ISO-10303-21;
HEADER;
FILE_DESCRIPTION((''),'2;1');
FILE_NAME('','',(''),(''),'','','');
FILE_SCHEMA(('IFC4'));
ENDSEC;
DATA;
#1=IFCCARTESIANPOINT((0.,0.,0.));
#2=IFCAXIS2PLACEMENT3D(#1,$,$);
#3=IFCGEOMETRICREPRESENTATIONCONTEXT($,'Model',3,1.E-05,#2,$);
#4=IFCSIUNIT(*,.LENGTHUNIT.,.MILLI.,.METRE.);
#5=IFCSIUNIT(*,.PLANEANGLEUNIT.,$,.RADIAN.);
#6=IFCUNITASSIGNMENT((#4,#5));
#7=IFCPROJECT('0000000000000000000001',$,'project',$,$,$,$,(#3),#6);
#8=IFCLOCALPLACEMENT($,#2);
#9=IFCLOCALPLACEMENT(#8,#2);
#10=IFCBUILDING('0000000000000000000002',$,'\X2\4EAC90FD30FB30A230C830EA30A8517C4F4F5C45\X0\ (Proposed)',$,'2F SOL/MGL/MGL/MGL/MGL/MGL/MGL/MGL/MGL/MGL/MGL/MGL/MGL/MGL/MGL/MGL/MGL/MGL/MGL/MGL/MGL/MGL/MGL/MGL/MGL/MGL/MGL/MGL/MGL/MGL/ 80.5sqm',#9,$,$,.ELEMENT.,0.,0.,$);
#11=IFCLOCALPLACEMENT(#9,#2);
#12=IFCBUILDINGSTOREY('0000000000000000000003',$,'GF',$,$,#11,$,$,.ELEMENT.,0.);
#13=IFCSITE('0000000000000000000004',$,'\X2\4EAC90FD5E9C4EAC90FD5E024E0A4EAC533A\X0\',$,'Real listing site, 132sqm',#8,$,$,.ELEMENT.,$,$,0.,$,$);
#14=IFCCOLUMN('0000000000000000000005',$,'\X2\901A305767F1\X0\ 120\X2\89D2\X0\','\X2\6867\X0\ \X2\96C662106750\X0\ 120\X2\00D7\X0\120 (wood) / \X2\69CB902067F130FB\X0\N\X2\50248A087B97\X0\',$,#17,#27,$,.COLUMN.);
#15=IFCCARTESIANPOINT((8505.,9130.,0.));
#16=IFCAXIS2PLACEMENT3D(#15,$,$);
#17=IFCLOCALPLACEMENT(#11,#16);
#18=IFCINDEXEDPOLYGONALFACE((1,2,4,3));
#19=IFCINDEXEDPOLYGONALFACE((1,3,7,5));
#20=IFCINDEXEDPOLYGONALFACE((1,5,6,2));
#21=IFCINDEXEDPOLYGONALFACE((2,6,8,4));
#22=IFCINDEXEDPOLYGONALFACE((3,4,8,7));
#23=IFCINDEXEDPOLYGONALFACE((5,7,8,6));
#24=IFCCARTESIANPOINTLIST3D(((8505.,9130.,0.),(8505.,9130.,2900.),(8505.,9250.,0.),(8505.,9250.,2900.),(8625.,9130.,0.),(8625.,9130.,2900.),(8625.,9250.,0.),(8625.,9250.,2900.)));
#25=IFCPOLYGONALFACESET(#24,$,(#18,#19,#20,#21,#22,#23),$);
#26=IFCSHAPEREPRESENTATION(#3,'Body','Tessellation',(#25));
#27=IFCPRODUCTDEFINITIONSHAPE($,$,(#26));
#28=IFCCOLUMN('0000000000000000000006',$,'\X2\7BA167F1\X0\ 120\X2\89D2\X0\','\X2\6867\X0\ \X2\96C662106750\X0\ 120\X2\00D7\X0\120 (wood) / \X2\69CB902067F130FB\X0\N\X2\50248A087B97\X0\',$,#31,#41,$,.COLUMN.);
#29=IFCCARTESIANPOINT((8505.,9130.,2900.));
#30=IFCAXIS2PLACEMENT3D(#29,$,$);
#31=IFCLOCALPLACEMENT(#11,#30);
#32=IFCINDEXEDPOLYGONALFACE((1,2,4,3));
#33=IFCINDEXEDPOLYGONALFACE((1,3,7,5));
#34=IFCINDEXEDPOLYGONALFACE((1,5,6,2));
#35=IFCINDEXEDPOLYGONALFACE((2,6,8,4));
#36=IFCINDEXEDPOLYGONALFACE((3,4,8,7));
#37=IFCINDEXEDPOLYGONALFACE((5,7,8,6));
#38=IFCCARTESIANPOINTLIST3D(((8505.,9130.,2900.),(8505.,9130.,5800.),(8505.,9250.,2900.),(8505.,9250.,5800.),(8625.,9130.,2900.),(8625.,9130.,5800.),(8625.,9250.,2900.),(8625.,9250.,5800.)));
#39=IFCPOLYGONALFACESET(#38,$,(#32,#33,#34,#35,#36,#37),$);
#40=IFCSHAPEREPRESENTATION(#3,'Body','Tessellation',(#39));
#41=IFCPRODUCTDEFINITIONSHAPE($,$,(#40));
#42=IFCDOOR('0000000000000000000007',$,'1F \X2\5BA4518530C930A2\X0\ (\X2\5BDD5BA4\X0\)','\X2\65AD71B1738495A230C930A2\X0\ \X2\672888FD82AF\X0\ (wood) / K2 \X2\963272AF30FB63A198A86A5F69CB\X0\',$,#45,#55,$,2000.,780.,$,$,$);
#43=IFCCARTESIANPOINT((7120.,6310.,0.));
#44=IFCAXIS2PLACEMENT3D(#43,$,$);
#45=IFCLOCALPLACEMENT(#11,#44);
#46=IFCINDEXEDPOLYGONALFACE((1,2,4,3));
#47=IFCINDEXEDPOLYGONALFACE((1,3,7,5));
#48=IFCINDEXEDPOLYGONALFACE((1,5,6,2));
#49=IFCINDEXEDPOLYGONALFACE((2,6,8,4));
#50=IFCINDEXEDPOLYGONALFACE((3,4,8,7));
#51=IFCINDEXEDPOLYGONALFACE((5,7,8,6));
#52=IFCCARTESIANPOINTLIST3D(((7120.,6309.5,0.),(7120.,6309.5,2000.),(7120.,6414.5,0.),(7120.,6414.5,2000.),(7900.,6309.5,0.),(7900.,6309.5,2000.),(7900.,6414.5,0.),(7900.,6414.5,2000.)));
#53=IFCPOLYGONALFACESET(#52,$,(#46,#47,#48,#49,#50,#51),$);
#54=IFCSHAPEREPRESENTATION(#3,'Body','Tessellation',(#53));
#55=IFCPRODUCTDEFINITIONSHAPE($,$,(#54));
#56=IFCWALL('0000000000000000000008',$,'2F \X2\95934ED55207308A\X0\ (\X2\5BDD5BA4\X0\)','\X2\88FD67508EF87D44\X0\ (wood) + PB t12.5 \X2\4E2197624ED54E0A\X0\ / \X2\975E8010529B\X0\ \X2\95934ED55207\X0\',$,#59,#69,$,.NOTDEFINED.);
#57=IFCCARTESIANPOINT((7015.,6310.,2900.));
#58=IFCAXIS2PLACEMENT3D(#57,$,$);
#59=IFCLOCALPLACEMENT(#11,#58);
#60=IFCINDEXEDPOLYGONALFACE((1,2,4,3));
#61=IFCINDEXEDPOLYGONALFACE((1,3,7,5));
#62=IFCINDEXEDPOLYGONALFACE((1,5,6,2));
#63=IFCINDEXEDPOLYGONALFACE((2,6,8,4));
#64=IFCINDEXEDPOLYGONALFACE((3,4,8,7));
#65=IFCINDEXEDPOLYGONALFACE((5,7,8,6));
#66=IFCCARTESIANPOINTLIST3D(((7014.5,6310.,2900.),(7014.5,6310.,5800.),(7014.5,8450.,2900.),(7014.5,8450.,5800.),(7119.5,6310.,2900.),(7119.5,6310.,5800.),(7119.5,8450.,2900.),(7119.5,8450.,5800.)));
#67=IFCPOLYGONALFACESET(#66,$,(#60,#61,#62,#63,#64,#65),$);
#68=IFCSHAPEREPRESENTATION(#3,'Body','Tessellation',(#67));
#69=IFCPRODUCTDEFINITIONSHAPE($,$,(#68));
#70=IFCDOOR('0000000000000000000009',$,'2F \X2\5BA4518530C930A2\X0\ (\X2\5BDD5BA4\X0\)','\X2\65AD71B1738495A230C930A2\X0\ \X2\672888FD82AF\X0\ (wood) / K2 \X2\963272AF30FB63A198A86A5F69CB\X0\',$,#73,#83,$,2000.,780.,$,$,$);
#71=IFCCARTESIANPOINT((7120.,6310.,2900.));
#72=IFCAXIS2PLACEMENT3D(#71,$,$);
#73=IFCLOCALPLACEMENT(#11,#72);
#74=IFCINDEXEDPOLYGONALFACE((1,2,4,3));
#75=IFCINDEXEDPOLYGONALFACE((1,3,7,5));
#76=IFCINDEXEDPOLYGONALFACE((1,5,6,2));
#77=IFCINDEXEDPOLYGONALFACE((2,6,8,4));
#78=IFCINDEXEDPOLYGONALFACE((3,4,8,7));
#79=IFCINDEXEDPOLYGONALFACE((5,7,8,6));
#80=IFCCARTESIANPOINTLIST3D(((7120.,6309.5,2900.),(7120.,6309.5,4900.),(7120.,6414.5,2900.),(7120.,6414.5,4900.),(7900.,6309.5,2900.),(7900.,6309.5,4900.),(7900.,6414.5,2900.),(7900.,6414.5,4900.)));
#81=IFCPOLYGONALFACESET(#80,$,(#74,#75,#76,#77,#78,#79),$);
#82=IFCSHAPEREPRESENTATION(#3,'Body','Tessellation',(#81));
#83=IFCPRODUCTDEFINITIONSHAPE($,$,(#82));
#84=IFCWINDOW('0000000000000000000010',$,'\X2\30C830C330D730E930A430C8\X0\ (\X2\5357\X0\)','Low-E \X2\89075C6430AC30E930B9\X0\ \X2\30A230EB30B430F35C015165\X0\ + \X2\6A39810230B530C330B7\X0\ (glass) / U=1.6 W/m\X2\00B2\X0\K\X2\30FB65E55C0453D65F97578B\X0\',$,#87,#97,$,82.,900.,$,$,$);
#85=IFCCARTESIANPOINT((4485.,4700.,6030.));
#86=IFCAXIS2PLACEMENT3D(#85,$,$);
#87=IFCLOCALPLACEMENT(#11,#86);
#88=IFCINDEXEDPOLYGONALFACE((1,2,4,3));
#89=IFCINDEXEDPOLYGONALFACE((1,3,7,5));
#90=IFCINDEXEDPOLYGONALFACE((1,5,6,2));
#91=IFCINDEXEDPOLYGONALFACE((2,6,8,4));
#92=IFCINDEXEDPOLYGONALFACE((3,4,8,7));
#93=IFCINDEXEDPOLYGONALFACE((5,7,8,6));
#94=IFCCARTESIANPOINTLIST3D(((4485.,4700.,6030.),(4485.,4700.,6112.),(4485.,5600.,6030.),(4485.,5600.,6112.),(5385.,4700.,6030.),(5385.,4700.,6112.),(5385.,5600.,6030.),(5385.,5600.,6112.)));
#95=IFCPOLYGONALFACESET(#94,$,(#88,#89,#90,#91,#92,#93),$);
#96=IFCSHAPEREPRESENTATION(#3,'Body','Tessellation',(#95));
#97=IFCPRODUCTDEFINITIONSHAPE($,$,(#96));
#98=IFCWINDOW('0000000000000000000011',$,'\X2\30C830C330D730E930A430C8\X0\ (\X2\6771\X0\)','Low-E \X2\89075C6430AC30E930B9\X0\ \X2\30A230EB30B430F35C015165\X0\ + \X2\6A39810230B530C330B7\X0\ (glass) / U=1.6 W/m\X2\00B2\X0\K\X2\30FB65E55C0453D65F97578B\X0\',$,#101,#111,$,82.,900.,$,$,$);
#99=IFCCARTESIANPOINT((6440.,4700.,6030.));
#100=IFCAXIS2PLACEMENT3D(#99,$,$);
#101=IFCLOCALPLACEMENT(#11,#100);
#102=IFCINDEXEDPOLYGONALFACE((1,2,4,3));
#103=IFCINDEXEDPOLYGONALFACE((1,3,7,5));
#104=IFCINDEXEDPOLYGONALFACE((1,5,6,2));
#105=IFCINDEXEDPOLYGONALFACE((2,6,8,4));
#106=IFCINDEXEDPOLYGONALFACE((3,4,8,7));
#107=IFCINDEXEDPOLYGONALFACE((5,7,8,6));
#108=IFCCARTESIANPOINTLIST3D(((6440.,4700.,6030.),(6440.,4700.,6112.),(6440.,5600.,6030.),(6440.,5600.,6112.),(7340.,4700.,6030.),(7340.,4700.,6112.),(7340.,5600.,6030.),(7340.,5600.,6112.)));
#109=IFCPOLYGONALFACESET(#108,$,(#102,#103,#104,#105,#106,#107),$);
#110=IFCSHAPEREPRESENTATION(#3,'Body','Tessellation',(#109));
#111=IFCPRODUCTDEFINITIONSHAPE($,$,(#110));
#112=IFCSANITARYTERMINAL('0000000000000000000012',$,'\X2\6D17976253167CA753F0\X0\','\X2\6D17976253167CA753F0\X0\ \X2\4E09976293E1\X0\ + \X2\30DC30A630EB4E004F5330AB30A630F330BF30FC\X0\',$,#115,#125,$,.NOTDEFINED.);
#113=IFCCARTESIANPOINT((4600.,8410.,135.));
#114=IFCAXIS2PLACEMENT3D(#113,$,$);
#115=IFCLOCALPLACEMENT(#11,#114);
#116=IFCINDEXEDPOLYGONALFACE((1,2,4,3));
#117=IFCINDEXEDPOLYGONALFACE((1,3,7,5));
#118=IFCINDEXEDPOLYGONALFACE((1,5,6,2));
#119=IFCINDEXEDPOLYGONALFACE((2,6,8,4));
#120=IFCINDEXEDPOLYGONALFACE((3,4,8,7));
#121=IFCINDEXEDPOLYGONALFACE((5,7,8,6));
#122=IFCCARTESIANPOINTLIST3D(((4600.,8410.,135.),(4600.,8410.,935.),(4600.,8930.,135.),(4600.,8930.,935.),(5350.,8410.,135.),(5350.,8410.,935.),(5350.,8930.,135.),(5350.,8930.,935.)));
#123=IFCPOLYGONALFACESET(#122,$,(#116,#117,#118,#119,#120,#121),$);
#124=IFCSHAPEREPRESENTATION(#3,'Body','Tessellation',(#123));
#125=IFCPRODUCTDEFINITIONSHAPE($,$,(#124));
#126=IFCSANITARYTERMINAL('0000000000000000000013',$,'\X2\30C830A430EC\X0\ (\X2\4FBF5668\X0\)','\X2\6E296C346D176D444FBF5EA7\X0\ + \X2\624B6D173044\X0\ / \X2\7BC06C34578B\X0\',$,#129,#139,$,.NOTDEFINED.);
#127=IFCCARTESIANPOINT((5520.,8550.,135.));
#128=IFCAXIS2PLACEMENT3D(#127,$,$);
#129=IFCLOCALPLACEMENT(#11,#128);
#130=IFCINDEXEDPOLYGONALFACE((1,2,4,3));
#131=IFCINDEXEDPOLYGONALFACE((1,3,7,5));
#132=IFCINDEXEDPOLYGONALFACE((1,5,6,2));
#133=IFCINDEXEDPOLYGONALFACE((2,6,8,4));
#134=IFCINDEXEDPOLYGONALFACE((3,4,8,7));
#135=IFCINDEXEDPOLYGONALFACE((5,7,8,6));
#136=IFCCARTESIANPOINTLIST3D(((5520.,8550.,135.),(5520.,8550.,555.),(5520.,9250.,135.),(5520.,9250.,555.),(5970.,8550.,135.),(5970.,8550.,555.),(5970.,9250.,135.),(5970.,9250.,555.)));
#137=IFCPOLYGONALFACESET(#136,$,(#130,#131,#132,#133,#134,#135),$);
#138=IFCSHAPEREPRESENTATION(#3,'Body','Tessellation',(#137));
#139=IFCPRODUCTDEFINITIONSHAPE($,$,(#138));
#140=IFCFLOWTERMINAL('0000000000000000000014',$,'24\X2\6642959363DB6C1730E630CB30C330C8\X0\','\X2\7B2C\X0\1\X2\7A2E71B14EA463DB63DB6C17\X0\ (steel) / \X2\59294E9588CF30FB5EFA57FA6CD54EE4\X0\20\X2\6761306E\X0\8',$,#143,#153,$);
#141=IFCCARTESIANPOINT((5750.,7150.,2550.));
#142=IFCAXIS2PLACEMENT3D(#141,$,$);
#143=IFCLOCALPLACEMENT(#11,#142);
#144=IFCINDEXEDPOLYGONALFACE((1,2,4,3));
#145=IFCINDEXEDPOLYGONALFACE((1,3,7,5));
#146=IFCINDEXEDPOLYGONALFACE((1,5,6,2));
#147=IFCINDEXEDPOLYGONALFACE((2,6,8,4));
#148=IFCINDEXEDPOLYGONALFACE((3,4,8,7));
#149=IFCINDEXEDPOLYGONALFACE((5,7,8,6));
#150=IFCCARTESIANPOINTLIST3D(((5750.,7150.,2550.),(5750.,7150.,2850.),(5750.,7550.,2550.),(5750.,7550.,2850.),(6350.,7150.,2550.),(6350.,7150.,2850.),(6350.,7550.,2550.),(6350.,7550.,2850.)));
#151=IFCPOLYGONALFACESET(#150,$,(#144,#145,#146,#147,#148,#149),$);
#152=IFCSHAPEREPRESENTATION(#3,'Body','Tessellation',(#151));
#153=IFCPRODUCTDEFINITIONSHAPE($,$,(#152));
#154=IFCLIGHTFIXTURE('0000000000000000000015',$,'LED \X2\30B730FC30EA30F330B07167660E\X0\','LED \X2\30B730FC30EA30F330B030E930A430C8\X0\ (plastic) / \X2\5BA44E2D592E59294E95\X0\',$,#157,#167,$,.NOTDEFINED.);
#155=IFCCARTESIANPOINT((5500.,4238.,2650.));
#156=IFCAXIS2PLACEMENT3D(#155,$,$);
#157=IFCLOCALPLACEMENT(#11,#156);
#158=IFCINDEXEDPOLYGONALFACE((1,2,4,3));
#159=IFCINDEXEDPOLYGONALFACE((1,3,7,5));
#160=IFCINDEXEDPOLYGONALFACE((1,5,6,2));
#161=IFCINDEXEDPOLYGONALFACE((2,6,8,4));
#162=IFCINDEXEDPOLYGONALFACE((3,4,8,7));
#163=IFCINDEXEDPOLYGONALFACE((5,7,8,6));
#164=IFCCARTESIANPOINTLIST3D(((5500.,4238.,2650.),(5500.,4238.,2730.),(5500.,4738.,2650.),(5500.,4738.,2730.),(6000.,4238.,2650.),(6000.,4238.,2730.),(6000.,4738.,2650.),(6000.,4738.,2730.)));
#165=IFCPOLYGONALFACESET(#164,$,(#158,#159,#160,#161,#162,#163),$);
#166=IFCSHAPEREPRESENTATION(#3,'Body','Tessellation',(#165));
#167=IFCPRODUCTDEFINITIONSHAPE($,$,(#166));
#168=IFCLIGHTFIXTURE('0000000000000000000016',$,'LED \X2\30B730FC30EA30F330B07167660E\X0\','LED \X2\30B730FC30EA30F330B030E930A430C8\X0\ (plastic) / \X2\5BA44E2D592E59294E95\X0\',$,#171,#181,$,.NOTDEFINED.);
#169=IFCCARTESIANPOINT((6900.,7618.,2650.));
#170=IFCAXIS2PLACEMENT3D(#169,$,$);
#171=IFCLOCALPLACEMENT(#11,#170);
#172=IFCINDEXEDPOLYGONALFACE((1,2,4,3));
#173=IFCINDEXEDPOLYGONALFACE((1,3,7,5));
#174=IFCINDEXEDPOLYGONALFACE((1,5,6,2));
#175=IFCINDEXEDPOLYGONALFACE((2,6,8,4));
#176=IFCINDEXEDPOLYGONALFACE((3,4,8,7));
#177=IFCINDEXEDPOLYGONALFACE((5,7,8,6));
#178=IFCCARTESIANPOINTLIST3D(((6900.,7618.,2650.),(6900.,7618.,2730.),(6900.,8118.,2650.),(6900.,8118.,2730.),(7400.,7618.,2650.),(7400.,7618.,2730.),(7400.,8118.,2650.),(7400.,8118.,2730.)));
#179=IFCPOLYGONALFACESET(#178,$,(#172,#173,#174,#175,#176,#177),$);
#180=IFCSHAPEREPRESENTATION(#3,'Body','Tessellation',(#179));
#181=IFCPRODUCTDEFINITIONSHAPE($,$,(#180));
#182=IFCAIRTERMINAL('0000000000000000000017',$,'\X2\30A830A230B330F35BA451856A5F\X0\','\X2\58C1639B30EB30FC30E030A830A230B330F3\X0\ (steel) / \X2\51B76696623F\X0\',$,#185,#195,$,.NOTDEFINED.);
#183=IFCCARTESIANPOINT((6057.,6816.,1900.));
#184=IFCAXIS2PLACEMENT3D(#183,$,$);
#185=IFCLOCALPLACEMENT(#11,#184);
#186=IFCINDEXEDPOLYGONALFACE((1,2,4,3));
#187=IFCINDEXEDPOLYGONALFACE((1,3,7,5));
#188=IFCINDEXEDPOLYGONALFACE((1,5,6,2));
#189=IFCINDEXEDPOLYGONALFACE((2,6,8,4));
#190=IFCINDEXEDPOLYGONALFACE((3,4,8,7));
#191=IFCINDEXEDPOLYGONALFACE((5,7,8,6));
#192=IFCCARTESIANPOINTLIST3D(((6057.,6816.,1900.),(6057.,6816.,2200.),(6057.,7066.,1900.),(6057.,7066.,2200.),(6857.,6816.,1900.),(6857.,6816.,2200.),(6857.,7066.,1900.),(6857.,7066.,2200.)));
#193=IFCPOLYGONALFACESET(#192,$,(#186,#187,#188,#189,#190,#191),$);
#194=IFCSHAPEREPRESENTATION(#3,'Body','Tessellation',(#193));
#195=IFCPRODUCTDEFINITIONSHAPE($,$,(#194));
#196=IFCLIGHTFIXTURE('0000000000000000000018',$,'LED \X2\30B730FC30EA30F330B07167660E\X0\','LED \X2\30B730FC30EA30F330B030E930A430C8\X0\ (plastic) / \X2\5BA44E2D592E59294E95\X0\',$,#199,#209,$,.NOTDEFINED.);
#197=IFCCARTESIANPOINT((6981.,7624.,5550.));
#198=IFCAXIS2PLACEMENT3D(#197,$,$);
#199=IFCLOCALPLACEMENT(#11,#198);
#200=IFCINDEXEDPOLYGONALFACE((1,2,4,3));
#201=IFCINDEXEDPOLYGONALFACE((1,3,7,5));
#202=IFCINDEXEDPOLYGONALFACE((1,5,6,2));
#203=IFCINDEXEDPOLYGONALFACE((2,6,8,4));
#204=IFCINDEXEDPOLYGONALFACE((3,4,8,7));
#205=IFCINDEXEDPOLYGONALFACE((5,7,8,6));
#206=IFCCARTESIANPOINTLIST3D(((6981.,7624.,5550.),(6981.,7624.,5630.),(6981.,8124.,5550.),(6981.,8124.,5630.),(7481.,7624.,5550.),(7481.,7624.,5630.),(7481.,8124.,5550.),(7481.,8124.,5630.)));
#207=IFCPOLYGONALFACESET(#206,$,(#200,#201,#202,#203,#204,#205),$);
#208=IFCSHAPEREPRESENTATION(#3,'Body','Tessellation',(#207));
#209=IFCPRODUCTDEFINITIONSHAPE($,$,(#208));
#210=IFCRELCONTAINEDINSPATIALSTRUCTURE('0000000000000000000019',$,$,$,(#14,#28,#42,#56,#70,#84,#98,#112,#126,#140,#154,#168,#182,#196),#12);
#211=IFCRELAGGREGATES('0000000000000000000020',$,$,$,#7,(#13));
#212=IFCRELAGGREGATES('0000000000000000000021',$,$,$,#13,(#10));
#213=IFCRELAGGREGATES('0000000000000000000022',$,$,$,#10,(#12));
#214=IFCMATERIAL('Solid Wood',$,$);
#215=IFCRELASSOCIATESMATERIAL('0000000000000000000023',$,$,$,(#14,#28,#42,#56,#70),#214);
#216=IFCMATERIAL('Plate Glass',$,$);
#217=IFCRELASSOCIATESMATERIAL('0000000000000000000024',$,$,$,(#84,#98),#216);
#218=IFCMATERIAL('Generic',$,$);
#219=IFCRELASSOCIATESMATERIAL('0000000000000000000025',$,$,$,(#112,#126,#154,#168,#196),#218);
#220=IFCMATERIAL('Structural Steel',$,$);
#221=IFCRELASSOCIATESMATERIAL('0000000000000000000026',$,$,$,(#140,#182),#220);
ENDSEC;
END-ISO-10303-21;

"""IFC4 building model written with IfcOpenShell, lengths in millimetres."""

from ifc_helpers import new_model, si_unit, frame, frame_2d, origin, place, context, project, spatial, rectangle, extrude, material, element, save


model = new_model("IFC4")

# Units and contexts
model_context = context("Model", 3, precision=1e-05, world=origin())
ifc_project = project(units=[si_unit("LENGTHUNIT", "METRE", prefix="MILLI"), si_unit("PLANEANGLEUNIT", "RADIAN")], contexts=[model_context])

# Site, building, storey
site_placement = place(None, origin())
site = spatial("IfcSite", under=ifc_project, at=site_placement, Name="京都府京都市上京区", ObjectType="Real listing site, 132sqm", CompositionType="ELEMENT", RefElevation=0.0)
building_placement = place(site_placement, origin())
building = spatial("IfcBuilding", under=site, at=building_placement, Name="京都・アトリエ兼住居 (Proposed)", ObjectType="2F SOL/MGL/MGL/MGL/MGL/MGL/MGL/MGL/MGL/MGL/MGL/MGL/MGL/MGL/MGL/MGL/MGL/MGL/MGL/MGL/MGL/MGL/MGL/MGL/MGL/MGL/MGL/MGL/MGL/MGL/ 80.5sqm", CompositionType="ELEMENT", ElevationOfRefHeight=0.0, ElevationOfTerrain=0.0)
storey_placement = place(building_placement, origin())
storey = spatial("IfcBuildingStorey", under=building, at=storey_placement, Name="GF", CompositionType="ELEMENT", Elevation=0.0)

# Columns
ifc_material_1 = material(Name="Solid Wood")
column_1_placement = place(storey_placement, frame((8505.0, 9130.0, 0.0)))
element("IfcColumn", 1, at=column_1_placement, inside=storey, material=ifc_material_1, Name="通し柱 120角", Description="桧 集成材 120×120 (wood) / 構造柱・N値計算", PredefinedType="COLUMN", context=model_context, shape_type="SweptSolid", body=[
    extrude(rectangle(XDim=120.0, YDim=120.0, at=frame_2d((60.0, 60.0))), frame((8505.0, 9130.0, 0.0)), (0.0, 0.0, 1.0), 2900.0),
])
column_2_placement = place(storey_placement, frame((8505.0, 9130.0, 2900.0)))
element("IfcColumn", 2, at=column_2_placement, inside=storey, material=ifc_material_1, Name="管柱 120角", Description="桧 集成材 120×120 (wood) / 構造柱・N値計算", PredefinedType="COLUMN", context=model_context, shape_type="SweptSolid", body=[
    extrude(rectangle(XDim=120.0, YDim=120.0, at=frame_2d((60.0, 60.0))), frame((8505.0, 9130.0, 2900.0)), (0.0, 0.0, 1.0), 2900.0),
])

# Door
door_1_placement = place(storey_placement, frame((7120.0, 6310.0, 0.0)))
element("IfcDoor", 3, at=door_1_placement, inside=storey, material=ifc_material_1, Name="1F 室内ドア (寝室)", Description="断熱玄関ドア 木製芯 (wood) / K2 防犯・採風機構", OverallHeight=2000.0, OverallWidth=780.0, context=model_context, shape_type="SweptSolid", body=[
    extrude(rectangle(XDim=780.0, YDim=105.0, at=frame_2d((390.0, 52.0))), frame((7120.0, 6310.0, 0.0)), (0.0, 0.0, 1.0), 2000.0),
])

# Wall
wall_1_placement = place(storey_placement, frame((7015.0, 6310.0, 2900.0)))
element("IfcWall", 4, at=wall_1_placement, inside=storey, material=ifc_material_1, Name="2F 間仕切り (寝室)", Description="製材軸組 (wood) + PB t12.5 両面仕上 / 非耐力 間仕切", PredefinedType="NOTDEFINED", context=model_context, shape_type="SweptSolid", body=[
    extrude(rectangle(XDim=105.0, YDim=2140.0, at=frame_2d((52.0, 1070.0))), frame((7015.0, 6310.0, 2900.0)), (0.0, 0.0, 1.0), 2900.0),
])

# Door
door_2_placement = place(storey_placement, frame((7120.0, 6310.0, 2900.0)))
element("IfcDoor", 5, at=door_2_placement, inside=storey, material=ifc_material_1, Name="2F 室内ドア (寝室)", Description="断熱玄関ドア 木製芯 (wood) / K2 防犯・採風機構", OverallHeight=2000.0, OverallWidth=780.0, context=model_context, shape_type="SweptSolid", body=[
    extrude(rectangle(XDim=780.0, YDim=105.0, at=frame_2d((390.0, 52.0))), frame((7120.0, 6310.0, 2900.0)), (0.0, 0.0, 1.0), 2000.0),
])

# Windows
ifc_material_2 = material(Name="Plate Glass")
window_1_placement = place(storey_placement, frame((4485.0, 4700.0, 6030.0)))
element("IfcWindow", 6, at=window_1_placement, inside=storey, material=ifc_material_2, Name="トップライト (南)", Description="Low-E 複層ガラス アルゴン封入 + 樹脂サッシ (glass) / U=1.6 W/m²K・日射取得型", OverallHeight=82.0, OverallWidth=900.0, context=model_context, shape_type="SweptSolid", body=[
    extrude(rectangle(XDim=900.0, YDim=900.0, at=frame_2d((450.0, 450.0))), frame((4485.0, 4700.0, 6030.0)), (0.0, 0.0, 1.0), 82.0),
])
window_2_placement = place(storey_placement, frame((6440.0, 4700.0, 6030.0)))
element("IfcWindow", 7, at=window_2_placement, inside=storey, material=ifc_material_2, Name="トップライト (東)", Description="Low-E 複層ガラス アルゴン封入 + 樹脂サッシ (glass) / U=1.6 W/m²K・日射取得型", OverallHeight=82.0, OverallWidth=900.0, context=model_context, shape_type="SweptSolid", body=[
    extrude(rectangle(XDim=900.0, YDim=900.0, at=frame_2d((450.0, 450.0))), frame((6440.0, 4700.0, 6030.0)), (0.0, 0.0, 1.0), 82.0),
])

# Sanitary terminals
ifc_material_3 = material(Name="Generic")
sanitary_terminal_1_placement = place(storey_placement, frame((4600.0, 8410.0, 135.0)))
element("IfcSanitaryTerminal", 8, at=sanitary_terminal_1_placement, inside=storey, material=ifc_material_3, Name="洗面化粧台", Description="洗面化粧台 三面鏡 + ボウル一体カウンター", PredefinedType="NOTDEFINED", context=model_context, shape_type="SweptSolid", body=[
    extrude(rectangle(XDim=750.0, YDim=520.0, at=frame_2d((375.0, 260.0))), frame((4600.0, 8410.0, 135.0)), (0.0, 0.0, 1.0), 800.0),
])
sanitary_terminal_2_placement = place(storey_placement, frame((5520.0, 8550.0, 135.0)))
element("IfcSanitaryTerminal", 9, at=sanitary_terminal_2_placement, inside=storey, material=ifc_material_3, Name="トイレ (便器)", Description="温水洗浄便座 + 手洗い / 節水型", PredefinedType="NOTDEFINED", context=model_context, shape_type="SweptSolid", body=[
    extrude(rectangle(XDim=450.0, YDim=700.0, at=frame_2d((225.0, 350.0))), frame((5520.0, 8550.0, 135.0)), (0.0, 0.0, 1.0), 420.0),
])

# Flow terminal
ifc_material_4 = material(Name="Structural Steel")
flow_terminal_placement = place(storey_placement, frame((5750.0, 7150.0, 2550.0)))
element("IfcFlowTerminal", 10, at=flow_terminal_placement, inside=storey, material=ifc_material_4, Name="24時間換気ユニット", Description="第1種熱交換換気 (steel) / 天井裏・建基法令20条の8", context=model_context, shape_type="SweptSolid", body=[
    extrude(rectangle(XDim=600.0, YDim=400.0, at=frame_2d((300.0, 200.0))), frame((5750.0, 7150.0, 2550.0)), (0.0, 0.0, 1.0), 300.0),
])

# Light fixtures
light_fixture_1_placement = place(storey_placement, frame((5500.0, 4238.0, 2650.0)))
element("IfcLightFixture", 11, at=light_fixture_1_placement, inside=storey, material=ifc_material_3, Name="LED シーリング照明", Description="LED シーリングライト (plastic) / 室中央天井", PredefinedType="NOTDEFINED", context=model_context, shape_type="SweptSolid", body=[
    extrude(rectangle(XDim=500.0, YDim=500.0, at=frame_2d((250.0, 250.0))), frame((5500.0, 4238.0, 2650.0)), (0.0, 0.0, 1.0), 80.0),
])
light_fixture_2_placement = place(storey_placement, frame((6900.0, 7618.0, 2650.0)))
element("IfcLightFixture", 12, at=light_fixture_2_placement, inside=storey, material=ifc_material_3, Name="LED シーリング照明", Description="LED シーリングライト (plastic) / 室中央天井", PredefinedType="NOTDEFINED", context=model_context, shape_type="SweptSolid", body=[
    extrude(rectangle(XDim=500.0, YDim=500.0, at=frame_2d((250.0, 250.0))), frame((6900.0, 7618.0, 2650.0)), (0.0, 0.0, 1.0), 80.0),
])

# Air terminal
air_terminal_placement = place(storey_placement, frame((6057.0, 6816.0, 1900.0)))
element("IfcAirTerminal", 13, at=air_terminal_placement, inside=storey, material=ifc_material_4, Name="エアコン室内機", Description="壁掛ルームエアコン (steel) / 冷暖房", PredefinedType="NOTDEFINED", context=model_context, shape_type="SweptSolid", body=[
    extrude(rectangle(XDim=800.0, YDim=250.0, at=frame_2d((400.0, 125.0))), frame((6057.0, 6816.0, 1900.0)), (0.0, 0.0, 1.0), 300.0),
])

# Light fixture
light_fixture_3_placement = place(storey_placement, frame((6981.0, 7624.0, 5550.0)))
element("IfcLightFixture", 14, at=light_fixture_3_placement, inside=storey, material=ifc_material_3, Name="LED シーリング照明", Description="LED シーリングライト (plastic) / 室中央天井", PredefinedType="NOTDEFINED", context=model_context, shape_type="SweptSolid", body=[
    extrude(rectangle(XDim=500.0, YDim=500.0, at=frame_2d((250.0, 250.0))), frame((6981.0, 7624.0, 5550.0)), (0.0, 0.0, 1.0), 80.0),
])

save(model, "model.ifc")
